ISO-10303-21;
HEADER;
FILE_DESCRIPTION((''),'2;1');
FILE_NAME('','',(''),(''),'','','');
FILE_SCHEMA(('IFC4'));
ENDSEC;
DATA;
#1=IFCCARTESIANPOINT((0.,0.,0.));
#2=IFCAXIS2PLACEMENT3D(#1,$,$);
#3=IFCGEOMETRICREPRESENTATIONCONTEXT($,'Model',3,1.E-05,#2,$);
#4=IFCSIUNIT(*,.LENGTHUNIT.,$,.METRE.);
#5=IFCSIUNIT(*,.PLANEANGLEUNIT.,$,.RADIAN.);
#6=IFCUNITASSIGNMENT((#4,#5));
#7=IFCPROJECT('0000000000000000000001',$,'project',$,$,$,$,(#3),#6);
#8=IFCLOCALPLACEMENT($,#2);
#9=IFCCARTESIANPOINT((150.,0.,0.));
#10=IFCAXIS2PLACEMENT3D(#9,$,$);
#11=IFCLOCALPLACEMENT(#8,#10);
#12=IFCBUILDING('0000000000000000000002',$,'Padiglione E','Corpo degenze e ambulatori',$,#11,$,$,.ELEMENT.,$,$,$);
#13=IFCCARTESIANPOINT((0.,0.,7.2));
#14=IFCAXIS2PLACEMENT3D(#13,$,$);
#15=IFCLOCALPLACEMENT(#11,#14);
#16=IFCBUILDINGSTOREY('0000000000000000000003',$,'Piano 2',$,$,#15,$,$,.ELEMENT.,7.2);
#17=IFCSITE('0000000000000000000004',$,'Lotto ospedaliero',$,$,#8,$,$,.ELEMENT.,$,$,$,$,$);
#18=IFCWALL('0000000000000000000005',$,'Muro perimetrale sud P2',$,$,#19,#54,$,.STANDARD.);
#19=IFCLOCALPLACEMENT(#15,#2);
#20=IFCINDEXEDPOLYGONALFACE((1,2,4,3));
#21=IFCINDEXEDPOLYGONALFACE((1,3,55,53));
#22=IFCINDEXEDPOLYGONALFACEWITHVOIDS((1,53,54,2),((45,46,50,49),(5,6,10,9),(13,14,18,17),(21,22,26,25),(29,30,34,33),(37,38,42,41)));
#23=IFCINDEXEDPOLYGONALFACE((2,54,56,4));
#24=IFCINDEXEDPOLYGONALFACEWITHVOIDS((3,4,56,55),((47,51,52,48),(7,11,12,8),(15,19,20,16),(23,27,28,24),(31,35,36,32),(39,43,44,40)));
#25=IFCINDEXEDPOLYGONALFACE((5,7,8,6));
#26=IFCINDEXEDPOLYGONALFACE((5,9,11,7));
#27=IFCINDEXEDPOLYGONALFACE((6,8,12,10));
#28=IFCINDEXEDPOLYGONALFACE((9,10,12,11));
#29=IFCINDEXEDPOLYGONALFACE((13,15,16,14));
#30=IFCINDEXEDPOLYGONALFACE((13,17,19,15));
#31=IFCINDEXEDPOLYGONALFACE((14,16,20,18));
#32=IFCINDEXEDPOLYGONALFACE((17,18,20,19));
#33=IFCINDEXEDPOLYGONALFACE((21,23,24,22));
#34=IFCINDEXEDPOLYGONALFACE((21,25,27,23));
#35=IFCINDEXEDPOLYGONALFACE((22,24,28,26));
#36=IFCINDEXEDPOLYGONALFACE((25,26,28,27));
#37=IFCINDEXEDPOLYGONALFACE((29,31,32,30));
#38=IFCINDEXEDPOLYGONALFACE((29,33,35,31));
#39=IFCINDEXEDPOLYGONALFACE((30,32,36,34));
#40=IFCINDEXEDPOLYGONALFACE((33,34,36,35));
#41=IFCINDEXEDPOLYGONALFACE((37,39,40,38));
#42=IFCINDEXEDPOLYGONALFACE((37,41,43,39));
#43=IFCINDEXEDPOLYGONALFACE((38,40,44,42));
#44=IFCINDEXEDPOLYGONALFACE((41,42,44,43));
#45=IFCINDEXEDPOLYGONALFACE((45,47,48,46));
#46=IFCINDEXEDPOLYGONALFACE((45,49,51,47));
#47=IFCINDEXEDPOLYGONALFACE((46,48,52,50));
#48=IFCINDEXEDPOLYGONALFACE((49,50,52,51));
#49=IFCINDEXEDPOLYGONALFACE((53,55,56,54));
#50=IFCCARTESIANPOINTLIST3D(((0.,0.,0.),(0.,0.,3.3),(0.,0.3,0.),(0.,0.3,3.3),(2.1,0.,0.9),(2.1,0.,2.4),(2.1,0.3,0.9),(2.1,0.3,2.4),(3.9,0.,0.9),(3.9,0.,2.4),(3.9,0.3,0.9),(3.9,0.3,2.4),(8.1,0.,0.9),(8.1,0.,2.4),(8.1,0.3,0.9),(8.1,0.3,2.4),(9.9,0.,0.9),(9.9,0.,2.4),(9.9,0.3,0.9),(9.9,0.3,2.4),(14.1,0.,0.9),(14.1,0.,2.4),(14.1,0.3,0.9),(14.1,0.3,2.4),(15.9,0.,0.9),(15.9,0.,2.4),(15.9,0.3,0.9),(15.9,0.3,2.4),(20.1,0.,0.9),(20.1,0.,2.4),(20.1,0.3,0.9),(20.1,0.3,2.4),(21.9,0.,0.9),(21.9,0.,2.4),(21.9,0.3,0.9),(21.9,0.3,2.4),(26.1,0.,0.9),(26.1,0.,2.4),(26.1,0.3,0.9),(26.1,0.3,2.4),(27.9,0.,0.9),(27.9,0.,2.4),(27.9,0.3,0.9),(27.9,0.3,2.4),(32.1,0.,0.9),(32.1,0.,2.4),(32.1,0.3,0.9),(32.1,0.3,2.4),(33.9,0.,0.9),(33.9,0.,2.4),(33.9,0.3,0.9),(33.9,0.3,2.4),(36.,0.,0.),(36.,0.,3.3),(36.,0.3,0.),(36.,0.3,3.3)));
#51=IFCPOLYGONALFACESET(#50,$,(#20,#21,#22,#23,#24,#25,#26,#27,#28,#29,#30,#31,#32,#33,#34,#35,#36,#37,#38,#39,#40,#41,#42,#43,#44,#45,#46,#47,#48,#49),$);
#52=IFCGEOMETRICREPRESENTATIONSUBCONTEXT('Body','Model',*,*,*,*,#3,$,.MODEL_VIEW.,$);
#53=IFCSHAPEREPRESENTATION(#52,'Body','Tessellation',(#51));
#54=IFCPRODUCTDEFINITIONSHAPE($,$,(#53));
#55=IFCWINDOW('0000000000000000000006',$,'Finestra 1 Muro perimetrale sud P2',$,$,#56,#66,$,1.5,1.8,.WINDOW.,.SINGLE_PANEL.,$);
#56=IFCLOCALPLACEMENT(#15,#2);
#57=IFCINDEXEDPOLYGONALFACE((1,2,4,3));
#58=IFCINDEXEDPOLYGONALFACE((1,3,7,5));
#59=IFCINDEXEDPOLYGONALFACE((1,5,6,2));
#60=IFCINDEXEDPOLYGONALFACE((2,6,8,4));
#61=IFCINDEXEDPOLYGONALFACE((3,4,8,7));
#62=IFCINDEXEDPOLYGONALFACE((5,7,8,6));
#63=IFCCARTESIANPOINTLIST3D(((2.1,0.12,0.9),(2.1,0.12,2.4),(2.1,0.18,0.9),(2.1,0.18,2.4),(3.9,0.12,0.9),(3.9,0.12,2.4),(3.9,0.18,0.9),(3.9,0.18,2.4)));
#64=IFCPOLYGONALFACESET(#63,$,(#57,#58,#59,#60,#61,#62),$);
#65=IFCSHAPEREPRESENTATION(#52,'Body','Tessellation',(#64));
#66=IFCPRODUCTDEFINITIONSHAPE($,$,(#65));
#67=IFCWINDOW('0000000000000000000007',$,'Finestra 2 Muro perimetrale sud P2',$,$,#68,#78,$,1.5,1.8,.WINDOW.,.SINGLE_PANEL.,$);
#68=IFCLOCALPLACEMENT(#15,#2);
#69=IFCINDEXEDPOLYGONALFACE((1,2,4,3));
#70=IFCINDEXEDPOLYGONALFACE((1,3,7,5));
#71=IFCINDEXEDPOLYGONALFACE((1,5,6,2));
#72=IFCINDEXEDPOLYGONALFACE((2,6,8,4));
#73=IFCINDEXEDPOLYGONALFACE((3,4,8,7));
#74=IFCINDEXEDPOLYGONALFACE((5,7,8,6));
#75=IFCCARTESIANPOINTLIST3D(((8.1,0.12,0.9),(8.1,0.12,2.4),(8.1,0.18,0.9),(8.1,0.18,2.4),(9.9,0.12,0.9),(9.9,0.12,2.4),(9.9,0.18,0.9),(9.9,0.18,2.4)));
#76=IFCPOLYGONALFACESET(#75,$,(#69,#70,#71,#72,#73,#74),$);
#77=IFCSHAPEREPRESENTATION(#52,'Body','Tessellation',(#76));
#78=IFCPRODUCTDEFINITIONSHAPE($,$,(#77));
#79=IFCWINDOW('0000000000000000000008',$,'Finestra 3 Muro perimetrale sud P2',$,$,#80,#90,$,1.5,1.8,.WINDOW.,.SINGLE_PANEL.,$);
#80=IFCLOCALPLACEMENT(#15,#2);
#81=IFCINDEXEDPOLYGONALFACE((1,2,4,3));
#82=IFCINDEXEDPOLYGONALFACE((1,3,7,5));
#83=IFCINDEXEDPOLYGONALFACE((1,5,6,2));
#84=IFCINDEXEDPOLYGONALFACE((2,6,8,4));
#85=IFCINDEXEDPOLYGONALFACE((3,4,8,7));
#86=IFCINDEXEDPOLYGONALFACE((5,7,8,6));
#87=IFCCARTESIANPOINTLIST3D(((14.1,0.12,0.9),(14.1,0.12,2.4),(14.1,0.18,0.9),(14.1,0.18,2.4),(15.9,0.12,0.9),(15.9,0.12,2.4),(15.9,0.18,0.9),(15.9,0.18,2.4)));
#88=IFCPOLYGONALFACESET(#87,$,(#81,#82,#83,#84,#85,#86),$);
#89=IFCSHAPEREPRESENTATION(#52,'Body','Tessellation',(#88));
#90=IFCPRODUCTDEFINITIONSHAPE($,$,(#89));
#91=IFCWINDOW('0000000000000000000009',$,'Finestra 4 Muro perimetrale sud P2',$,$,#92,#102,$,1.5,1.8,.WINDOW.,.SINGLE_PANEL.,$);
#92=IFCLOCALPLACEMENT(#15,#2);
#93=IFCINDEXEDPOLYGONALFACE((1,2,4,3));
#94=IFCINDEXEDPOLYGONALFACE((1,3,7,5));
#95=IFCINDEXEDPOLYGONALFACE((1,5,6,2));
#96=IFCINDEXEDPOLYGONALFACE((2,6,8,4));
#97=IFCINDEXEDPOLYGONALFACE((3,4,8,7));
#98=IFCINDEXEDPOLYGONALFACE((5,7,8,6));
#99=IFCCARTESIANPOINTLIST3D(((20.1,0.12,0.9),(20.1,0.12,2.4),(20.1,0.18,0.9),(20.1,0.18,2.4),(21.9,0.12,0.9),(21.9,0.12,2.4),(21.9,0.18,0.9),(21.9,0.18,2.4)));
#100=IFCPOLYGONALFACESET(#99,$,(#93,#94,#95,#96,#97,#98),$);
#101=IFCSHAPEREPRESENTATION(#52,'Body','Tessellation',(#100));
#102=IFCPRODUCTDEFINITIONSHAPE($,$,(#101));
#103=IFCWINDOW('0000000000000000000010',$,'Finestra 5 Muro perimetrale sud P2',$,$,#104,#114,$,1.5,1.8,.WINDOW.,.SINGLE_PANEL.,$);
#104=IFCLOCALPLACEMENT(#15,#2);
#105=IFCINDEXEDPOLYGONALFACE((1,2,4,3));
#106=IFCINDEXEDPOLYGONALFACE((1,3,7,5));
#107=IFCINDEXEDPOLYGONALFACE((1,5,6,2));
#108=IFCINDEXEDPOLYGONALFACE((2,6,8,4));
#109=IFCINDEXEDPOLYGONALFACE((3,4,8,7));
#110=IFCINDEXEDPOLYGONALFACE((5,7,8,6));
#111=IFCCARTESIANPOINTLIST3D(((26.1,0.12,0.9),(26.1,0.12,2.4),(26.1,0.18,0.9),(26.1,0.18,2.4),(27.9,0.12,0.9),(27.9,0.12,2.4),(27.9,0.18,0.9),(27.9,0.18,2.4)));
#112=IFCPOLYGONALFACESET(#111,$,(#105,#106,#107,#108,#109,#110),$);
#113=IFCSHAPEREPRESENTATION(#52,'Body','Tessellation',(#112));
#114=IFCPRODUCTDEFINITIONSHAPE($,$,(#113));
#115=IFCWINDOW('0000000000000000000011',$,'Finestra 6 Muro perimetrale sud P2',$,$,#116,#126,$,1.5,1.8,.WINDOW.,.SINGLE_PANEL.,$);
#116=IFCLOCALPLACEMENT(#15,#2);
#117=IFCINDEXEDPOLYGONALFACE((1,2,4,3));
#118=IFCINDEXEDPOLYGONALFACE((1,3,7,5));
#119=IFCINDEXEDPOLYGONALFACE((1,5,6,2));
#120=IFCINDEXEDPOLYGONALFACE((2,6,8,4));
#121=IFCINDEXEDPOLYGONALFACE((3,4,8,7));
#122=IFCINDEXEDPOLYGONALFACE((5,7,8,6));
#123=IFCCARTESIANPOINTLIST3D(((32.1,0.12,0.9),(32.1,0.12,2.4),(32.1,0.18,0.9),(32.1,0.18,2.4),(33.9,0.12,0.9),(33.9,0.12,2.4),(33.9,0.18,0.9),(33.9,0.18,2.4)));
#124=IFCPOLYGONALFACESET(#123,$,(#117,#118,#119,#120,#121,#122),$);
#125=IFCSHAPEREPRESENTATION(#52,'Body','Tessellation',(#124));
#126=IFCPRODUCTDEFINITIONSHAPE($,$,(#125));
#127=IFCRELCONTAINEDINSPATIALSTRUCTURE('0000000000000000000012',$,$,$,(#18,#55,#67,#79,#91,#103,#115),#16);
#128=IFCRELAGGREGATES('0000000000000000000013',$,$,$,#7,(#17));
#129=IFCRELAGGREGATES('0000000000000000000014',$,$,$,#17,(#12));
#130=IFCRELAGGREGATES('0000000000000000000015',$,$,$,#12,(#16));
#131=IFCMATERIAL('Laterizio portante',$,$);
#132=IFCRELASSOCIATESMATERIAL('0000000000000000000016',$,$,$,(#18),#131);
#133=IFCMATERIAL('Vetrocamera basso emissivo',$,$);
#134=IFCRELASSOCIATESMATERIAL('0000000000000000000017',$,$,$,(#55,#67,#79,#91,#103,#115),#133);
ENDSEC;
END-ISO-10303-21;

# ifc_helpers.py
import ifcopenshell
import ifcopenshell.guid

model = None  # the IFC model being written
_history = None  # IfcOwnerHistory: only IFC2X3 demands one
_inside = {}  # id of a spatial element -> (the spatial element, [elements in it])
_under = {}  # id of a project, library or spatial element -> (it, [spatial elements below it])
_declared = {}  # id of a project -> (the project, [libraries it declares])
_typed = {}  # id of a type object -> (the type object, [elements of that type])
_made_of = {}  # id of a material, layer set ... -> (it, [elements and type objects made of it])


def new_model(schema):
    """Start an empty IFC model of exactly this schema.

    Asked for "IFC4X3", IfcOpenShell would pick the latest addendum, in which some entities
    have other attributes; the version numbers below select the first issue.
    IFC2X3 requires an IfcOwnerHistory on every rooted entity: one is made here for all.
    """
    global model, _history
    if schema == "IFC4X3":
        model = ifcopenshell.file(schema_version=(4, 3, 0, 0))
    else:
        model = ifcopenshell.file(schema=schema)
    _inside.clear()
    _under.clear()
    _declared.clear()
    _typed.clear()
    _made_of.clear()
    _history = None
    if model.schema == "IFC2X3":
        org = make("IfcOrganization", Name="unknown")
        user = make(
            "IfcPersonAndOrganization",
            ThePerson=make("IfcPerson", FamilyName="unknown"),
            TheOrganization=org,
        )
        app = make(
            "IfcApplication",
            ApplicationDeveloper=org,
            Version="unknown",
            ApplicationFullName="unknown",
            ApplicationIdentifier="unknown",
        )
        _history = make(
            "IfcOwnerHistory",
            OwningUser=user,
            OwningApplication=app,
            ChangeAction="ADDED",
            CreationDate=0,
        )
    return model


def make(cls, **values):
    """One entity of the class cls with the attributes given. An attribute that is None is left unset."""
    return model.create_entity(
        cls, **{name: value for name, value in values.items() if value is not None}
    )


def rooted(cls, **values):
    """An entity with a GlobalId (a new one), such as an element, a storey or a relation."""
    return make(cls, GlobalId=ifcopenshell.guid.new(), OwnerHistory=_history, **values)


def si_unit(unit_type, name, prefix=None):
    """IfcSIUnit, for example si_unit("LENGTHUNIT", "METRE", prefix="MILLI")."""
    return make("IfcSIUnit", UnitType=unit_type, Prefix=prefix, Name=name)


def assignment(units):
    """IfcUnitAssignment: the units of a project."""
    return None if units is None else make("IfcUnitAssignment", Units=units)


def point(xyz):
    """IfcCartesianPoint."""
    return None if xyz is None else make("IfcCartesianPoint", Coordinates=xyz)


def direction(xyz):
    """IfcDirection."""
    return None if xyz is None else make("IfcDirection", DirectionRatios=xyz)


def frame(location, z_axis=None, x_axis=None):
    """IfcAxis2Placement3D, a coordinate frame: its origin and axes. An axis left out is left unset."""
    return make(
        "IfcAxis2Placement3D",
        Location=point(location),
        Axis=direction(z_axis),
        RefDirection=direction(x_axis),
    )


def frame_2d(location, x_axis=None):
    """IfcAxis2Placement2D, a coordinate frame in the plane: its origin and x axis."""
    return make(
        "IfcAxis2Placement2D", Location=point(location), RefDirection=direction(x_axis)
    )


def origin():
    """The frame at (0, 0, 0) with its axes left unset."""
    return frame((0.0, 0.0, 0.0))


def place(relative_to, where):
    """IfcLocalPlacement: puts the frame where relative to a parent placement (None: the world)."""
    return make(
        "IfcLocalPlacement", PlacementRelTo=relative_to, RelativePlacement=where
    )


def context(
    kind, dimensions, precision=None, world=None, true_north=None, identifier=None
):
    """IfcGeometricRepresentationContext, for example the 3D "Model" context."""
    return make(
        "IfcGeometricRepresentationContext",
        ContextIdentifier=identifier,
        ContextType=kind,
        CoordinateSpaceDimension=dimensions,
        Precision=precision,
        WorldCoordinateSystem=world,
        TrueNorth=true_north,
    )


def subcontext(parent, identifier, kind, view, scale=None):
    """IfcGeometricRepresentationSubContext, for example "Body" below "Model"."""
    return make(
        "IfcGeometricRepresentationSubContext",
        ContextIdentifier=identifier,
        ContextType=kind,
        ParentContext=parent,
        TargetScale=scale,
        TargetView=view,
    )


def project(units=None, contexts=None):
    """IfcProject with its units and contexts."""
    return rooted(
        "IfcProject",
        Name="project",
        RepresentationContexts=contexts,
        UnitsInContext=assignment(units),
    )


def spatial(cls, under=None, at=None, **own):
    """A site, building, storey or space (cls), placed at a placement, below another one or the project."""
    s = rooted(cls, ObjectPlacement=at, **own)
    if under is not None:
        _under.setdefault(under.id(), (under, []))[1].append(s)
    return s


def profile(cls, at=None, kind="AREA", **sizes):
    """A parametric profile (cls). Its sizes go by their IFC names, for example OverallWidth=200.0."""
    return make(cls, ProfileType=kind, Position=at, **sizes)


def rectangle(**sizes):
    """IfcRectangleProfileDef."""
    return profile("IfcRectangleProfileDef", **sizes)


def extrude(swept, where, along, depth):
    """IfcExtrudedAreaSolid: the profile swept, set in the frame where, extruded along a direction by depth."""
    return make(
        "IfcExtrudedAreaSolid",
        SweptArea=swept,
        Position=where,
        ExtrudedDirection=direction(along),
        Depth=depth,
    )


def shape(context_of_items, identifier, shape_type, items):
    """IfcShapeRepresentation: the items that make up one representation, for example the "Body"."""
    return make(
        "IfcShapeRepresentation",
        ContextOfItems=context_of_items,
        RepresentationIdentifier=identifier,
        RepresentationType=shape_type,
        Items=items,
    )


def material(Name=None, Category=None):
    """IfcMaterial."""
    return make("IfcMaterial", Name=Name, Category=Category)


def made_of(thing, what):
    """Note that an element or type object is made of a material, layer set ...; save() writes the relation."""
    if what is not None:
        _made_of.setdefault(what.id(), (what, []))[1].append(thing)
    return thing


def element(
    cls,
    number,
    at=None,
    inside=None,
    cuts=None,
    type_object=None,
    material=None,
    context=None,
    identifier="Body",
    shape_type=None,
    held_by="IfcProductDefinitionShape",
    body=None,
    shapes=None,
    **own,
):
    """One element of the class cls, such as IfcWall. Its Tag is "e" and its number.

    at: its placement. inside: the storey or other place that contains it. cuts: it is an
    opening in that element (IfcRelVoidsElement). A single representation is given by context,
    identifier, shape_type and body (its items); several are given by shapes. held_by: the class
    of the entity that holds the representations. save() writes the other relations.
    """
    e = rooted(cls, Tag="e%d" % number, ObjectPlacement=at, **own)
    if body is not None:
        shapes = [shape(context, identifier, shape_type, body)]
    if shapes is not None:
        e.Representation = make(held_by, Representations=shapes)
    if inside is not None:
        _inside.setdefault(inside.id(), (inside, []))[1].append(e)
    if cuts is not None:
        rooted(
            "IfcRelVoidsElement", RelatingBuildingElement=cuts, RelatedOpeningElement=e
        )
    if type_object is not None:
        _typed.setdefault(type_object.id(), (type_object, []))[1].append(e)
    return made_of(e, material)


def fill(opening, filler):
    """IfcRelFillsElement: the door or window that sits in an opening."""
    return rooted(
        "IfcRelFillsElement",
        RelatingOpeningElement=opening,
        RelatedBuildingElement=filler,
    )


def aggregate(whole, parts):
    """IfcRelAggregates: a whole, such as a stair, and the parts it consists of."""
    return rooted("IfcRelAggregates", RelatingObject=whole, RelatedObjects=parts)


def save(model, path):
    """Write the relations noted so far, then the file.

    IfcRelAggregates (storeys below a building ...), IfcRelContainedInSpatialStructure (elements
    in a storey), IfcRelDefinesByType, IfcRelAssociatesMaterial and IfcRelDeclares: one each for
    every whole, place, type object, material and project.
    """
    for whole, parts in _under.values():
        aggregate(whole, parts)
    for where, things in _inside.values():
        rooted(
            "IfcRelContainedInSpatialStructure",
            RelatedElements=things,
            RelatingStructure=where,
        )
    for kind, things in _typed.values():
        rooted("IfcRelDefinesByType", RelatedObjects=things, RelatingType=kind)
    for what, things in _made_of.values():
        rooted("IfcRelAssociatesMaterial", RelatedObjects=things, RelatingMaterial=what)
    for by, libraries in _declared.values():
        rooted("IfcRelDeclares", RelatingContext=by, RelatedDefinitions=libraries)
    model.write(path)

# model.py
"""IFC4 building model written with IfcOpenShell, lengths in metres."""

from ifc_helpers import new_model, si_unit, frame, frame_2d, origin, place, context, subcontext, project, spatial, rectangle, extrude, material, element, fill, save


model = new_model("IFC4")

# Units and contexts
model_context = context("Model", 3, precision=1e-05, world=origin())
body_context = subcontext(model_context, "Body", "Model", "MODEL_VIEW")
ifc_project = project(units=[si_unit("LENGTHUNIT", "METRE"), si_unit("PLANEANGLEUNIT", "RADIAN")], contexts=[model_context])

# Site, building, storey
site_placement = place(None, origin())
site = spatial("IfcSite", under=ifc_project, at=site_placement, Name="Lotto ospedaliero", CompositionType="ELEMENT")
building_placement = place(site_placement, frame((150.0, 0.0, 0.0)))
building = spatial("IfcBuilding", under=site, at=building_placement, Name="Padiglione E", Description="Corpo degenze e ambulatori", CompositionType="ELEMENT")
storey_placement = place(building_placement, frame((0.0, 0.0, 7.2)))
storey = spatial("IfcBuildingStorey", under=building, at=storey_placement, Name="Piano 2", CompositionType="ELEMENT", Elevation=7.2)

# Wall, openings, windows
ifc_material_1 = material(Name="Laterizio portante")
wall_1_placement = place(storey_placement, origin())
wall_1 = element("IfcWall", 1, at=wall_1_placement, inside=storey, material=ifc_material_1, Name="Muro perimetrale sud P2", PredefinedType="STANDARD", context=body_context, shape_type="SweptSolid", body=[
    extrude(rectangle(XDim=36.0, YDim=0.3, at=frame_2d((18.0, 0.15))), origin(), (0.0, 0.0, 1.0), 3.3),
])
opening_1_placement = place(wall_1_placement, frame((2.1, -0.1, 0.9)))
opening_1 = element("IfcOpeningElement", 2, at=opening_1_placement, cuts=wall_1, PredefinedType="OPENING", context=body_context, shape_type="SweptSolid", body=[
    extrude(rectangle(XDim=1.8, YDim=0.5, at=frame_2d((0.9, 0.25))), origin(), (0.0, 0.0, 1.0), 1.5),
])
opening_2_placement = place(wall_1_placement, frame((8.1, -0.1, 0.9)))
opening_2 = element("IfcOpeningElement", 3, at=opening_2_placement, cuts=wall_1, PredefinedType="OPENING", context=body_context, shape_type="SweptSolid", body=[
    extrude(rectangle(XDim=1.8, YDim=0.5, at=frame_2d((0.9, 0.25))), origin(), (0.0, 0.0, 1.0), 1.5),
])
opening_3_placement = place(wall_1_placement, frame((14.1, -0.1, 0.9)))
opening_3 = element("IfcOpeningElement", 4, at=opening_3_placement, cuts=wall_1, PredefinedType="OPENING", context=body_context, shape_type="SweptSolid", body=[
    extrude(rectangle(XDim=1.8, YDim=0.5, at=frame_2d((0.9, 0.25))), origin(), (0.0, 0.0, 1.0), 1.5),
])
opening_4_placement = place(wall_1_placement, frame((20.1, -0.1, 0.9)))
opening_4 = element("IfcOpeningElement", 5, at=opening_4_placement, cuts=wall_1, PredefinedType="OPENING", context=body_context, shape_type="SweptSolid", body=[
    extrude(rectangle(XDim=1.8, YDim=0.5, at=frame_2d((0.9, 0.25))), origin(), (0.0, 0.0, 1.0), 1.5),
])
opening_5_placement = place(wall_1_placement, frame((26.1, -0.1, 0.9)))
opening_5 = element("IfcOpeningElement", 6, at=opening_5_placement, cuts=wall_1, PredefinedType="OPENING", context=body_context, shape_type="SweptSolid", body=[
    extrude(rectangle(XDim=1.8, YDim=0.5, at=frame_2d((0.9, 0.25))), origin(), (0.0, 0.0, 1.0), 1.5),
])
opening_6_placement = place(wall_1_placement, frame((32.1, -0.1, 0.9)))
opening_6 = element("IfcOpeningElement", 7, at=opening_6_placement, cuts=wall_1, PredefinedType="OPENING", context=body_context, shape_type="SweptSolid", body=[
    extrude(rectangle(XDim=1.8, YDim=0.5, at=frame_2d((0.9, 0.25))), origin(), (0.0, 0.0, 1.0), 1.5),
])
ifc_material_2 = material(Name="Vetrocamera basso emissivo")
window_1_placement = place(wall_1_placement, frame((2.1, 0.12, 0.9)))
window_1 = element("IfcWindow", 8, at=window_1_placement, inside=storey, material=ifc_material_2, Name="Finestra 1 Muro perimetrale sud P2", OverallHeight=1.5, OverallWidth=1.8, PartitioningType="SINGLE_PANEL", PredefinedType="WINDOW", context=body_context, shape_type="SweptSolid", body=[
    extrude(rectangle(XDim=1.8, YDim=0.06, at=frame_2d((0.9, 0.03))), origin(), (0.0, 0.0, 1.0), 1.5),
])
fill(opening_1, window_1)
window_2_placement = place(wall_1_placement, frame((8.1, 0.12, 0.9)))
window_2 = element("IfcWindow", 9, at=window_2_placement, inside=storey, material=ifc_material_2, Name="Finestra 2 Muro perimetrale sud P2", OverallHeight=1.5, OverallWidth=1.8, PartitioningType="SINGLE_PANEL", PredefinedType="WINDOW", context=body_context, shape_type="SweptSolid", body=[
    extrude(rectangle(XDim=1.8, YDim=0.06, at=frame_2d((0.9, 0.03))), origin(), (0.0, 0.0, 1.0), 1.5),
])
fill(opening_2, window_2)
window_3_placement = place(wall_1_placement, frame((14.1, 0.12, 0.9)))
window_3 = element("IfcWindow", 10, at=window_3_placement, inside=storey, material=ifc_material_2, Name="Finestra 3 Muro perimetrale sud P2", OverallHeight=1.5, OverallWidth=1.8, PartitioningType="SINGLE_PANEL", PredefinedType="WINDOW", context=body_context, shape_type="SweptSolid", body=[
    extrude(rectangle(XDim=1.8, YDim=0.06, at=frame_2d((0.9, 0.03))), origin(), (0.0, 0.0, 1.0), 1.5),
])
fill(opening_3, window_3)
window_4_placement = place(wall_1_placement, frame((20.1, 0.12, 0.9)))
window_4 = element("IfcWindow", 11, at=window_4_placement, inside=storey, material=ifc_material_2, Name="Finestra 4 Muro perimetrale sud P2", OverallHeight=1.5, OverallWidth=1.8, PartitioningType="SINGLE_PANEL", PredefinedType="WINDOW", context=body_context, shape_type="SweptSolid", body=[
    extrude(rectangle(XDim=1.8, YDim=0.06, at=frame_2d((0.9, 0.03))), origin(), (0.0, 0.0, 1.0), 1.5),
])
fill(opening_4, window_4)
window_5_placement = place(wall_1_placement, frame((26.1, 0.12, 0.9)))
window_5 = element("IfcWindow", 12, at=window_5_placement, inside=storey, material=ifc_material_2, Name="Finestra 5 Muro perimetrale sud P2", OverallHeight=1.5, OverallWidth=1.8, PartitioningType="SINGLE_PANEL", PredefinedType="WINDOW", context=body_context, shape_type="SweptSolid", body=[
    extrude(rectangle(XDim=1.8, YDim=0.06, at=frame_2d((0.9, 0.03))), origin(), (0.0, 0.0, 1.0), 1.5),
])
fill(opening_5, window_5)
window_6_placement = place(wall_1_placement, frame((32.1, 0.12, 0.9)))
window_6 = element("IfcWindow", 13, at=window_6_placement, inside=storey, material=ifc_material_2, Name="Finestra 6 Muro perimetrale sud P2", OverallHeight=1.5, OverallWidth=1.8, PartitioningType="SINGLE_PANEL", PredefinedType="WINDOW", context=body_context, shape_type="SweptSolid", body=[
    extrude(rectangle(XDim=1.8, YDim=0.06, at=frame_2d((0.9, 0.03))), origin(), (0.0, 0.0, 1.0), 1.5),
])
fill(opening_6, window_6)

save(model, "model.ifc")
